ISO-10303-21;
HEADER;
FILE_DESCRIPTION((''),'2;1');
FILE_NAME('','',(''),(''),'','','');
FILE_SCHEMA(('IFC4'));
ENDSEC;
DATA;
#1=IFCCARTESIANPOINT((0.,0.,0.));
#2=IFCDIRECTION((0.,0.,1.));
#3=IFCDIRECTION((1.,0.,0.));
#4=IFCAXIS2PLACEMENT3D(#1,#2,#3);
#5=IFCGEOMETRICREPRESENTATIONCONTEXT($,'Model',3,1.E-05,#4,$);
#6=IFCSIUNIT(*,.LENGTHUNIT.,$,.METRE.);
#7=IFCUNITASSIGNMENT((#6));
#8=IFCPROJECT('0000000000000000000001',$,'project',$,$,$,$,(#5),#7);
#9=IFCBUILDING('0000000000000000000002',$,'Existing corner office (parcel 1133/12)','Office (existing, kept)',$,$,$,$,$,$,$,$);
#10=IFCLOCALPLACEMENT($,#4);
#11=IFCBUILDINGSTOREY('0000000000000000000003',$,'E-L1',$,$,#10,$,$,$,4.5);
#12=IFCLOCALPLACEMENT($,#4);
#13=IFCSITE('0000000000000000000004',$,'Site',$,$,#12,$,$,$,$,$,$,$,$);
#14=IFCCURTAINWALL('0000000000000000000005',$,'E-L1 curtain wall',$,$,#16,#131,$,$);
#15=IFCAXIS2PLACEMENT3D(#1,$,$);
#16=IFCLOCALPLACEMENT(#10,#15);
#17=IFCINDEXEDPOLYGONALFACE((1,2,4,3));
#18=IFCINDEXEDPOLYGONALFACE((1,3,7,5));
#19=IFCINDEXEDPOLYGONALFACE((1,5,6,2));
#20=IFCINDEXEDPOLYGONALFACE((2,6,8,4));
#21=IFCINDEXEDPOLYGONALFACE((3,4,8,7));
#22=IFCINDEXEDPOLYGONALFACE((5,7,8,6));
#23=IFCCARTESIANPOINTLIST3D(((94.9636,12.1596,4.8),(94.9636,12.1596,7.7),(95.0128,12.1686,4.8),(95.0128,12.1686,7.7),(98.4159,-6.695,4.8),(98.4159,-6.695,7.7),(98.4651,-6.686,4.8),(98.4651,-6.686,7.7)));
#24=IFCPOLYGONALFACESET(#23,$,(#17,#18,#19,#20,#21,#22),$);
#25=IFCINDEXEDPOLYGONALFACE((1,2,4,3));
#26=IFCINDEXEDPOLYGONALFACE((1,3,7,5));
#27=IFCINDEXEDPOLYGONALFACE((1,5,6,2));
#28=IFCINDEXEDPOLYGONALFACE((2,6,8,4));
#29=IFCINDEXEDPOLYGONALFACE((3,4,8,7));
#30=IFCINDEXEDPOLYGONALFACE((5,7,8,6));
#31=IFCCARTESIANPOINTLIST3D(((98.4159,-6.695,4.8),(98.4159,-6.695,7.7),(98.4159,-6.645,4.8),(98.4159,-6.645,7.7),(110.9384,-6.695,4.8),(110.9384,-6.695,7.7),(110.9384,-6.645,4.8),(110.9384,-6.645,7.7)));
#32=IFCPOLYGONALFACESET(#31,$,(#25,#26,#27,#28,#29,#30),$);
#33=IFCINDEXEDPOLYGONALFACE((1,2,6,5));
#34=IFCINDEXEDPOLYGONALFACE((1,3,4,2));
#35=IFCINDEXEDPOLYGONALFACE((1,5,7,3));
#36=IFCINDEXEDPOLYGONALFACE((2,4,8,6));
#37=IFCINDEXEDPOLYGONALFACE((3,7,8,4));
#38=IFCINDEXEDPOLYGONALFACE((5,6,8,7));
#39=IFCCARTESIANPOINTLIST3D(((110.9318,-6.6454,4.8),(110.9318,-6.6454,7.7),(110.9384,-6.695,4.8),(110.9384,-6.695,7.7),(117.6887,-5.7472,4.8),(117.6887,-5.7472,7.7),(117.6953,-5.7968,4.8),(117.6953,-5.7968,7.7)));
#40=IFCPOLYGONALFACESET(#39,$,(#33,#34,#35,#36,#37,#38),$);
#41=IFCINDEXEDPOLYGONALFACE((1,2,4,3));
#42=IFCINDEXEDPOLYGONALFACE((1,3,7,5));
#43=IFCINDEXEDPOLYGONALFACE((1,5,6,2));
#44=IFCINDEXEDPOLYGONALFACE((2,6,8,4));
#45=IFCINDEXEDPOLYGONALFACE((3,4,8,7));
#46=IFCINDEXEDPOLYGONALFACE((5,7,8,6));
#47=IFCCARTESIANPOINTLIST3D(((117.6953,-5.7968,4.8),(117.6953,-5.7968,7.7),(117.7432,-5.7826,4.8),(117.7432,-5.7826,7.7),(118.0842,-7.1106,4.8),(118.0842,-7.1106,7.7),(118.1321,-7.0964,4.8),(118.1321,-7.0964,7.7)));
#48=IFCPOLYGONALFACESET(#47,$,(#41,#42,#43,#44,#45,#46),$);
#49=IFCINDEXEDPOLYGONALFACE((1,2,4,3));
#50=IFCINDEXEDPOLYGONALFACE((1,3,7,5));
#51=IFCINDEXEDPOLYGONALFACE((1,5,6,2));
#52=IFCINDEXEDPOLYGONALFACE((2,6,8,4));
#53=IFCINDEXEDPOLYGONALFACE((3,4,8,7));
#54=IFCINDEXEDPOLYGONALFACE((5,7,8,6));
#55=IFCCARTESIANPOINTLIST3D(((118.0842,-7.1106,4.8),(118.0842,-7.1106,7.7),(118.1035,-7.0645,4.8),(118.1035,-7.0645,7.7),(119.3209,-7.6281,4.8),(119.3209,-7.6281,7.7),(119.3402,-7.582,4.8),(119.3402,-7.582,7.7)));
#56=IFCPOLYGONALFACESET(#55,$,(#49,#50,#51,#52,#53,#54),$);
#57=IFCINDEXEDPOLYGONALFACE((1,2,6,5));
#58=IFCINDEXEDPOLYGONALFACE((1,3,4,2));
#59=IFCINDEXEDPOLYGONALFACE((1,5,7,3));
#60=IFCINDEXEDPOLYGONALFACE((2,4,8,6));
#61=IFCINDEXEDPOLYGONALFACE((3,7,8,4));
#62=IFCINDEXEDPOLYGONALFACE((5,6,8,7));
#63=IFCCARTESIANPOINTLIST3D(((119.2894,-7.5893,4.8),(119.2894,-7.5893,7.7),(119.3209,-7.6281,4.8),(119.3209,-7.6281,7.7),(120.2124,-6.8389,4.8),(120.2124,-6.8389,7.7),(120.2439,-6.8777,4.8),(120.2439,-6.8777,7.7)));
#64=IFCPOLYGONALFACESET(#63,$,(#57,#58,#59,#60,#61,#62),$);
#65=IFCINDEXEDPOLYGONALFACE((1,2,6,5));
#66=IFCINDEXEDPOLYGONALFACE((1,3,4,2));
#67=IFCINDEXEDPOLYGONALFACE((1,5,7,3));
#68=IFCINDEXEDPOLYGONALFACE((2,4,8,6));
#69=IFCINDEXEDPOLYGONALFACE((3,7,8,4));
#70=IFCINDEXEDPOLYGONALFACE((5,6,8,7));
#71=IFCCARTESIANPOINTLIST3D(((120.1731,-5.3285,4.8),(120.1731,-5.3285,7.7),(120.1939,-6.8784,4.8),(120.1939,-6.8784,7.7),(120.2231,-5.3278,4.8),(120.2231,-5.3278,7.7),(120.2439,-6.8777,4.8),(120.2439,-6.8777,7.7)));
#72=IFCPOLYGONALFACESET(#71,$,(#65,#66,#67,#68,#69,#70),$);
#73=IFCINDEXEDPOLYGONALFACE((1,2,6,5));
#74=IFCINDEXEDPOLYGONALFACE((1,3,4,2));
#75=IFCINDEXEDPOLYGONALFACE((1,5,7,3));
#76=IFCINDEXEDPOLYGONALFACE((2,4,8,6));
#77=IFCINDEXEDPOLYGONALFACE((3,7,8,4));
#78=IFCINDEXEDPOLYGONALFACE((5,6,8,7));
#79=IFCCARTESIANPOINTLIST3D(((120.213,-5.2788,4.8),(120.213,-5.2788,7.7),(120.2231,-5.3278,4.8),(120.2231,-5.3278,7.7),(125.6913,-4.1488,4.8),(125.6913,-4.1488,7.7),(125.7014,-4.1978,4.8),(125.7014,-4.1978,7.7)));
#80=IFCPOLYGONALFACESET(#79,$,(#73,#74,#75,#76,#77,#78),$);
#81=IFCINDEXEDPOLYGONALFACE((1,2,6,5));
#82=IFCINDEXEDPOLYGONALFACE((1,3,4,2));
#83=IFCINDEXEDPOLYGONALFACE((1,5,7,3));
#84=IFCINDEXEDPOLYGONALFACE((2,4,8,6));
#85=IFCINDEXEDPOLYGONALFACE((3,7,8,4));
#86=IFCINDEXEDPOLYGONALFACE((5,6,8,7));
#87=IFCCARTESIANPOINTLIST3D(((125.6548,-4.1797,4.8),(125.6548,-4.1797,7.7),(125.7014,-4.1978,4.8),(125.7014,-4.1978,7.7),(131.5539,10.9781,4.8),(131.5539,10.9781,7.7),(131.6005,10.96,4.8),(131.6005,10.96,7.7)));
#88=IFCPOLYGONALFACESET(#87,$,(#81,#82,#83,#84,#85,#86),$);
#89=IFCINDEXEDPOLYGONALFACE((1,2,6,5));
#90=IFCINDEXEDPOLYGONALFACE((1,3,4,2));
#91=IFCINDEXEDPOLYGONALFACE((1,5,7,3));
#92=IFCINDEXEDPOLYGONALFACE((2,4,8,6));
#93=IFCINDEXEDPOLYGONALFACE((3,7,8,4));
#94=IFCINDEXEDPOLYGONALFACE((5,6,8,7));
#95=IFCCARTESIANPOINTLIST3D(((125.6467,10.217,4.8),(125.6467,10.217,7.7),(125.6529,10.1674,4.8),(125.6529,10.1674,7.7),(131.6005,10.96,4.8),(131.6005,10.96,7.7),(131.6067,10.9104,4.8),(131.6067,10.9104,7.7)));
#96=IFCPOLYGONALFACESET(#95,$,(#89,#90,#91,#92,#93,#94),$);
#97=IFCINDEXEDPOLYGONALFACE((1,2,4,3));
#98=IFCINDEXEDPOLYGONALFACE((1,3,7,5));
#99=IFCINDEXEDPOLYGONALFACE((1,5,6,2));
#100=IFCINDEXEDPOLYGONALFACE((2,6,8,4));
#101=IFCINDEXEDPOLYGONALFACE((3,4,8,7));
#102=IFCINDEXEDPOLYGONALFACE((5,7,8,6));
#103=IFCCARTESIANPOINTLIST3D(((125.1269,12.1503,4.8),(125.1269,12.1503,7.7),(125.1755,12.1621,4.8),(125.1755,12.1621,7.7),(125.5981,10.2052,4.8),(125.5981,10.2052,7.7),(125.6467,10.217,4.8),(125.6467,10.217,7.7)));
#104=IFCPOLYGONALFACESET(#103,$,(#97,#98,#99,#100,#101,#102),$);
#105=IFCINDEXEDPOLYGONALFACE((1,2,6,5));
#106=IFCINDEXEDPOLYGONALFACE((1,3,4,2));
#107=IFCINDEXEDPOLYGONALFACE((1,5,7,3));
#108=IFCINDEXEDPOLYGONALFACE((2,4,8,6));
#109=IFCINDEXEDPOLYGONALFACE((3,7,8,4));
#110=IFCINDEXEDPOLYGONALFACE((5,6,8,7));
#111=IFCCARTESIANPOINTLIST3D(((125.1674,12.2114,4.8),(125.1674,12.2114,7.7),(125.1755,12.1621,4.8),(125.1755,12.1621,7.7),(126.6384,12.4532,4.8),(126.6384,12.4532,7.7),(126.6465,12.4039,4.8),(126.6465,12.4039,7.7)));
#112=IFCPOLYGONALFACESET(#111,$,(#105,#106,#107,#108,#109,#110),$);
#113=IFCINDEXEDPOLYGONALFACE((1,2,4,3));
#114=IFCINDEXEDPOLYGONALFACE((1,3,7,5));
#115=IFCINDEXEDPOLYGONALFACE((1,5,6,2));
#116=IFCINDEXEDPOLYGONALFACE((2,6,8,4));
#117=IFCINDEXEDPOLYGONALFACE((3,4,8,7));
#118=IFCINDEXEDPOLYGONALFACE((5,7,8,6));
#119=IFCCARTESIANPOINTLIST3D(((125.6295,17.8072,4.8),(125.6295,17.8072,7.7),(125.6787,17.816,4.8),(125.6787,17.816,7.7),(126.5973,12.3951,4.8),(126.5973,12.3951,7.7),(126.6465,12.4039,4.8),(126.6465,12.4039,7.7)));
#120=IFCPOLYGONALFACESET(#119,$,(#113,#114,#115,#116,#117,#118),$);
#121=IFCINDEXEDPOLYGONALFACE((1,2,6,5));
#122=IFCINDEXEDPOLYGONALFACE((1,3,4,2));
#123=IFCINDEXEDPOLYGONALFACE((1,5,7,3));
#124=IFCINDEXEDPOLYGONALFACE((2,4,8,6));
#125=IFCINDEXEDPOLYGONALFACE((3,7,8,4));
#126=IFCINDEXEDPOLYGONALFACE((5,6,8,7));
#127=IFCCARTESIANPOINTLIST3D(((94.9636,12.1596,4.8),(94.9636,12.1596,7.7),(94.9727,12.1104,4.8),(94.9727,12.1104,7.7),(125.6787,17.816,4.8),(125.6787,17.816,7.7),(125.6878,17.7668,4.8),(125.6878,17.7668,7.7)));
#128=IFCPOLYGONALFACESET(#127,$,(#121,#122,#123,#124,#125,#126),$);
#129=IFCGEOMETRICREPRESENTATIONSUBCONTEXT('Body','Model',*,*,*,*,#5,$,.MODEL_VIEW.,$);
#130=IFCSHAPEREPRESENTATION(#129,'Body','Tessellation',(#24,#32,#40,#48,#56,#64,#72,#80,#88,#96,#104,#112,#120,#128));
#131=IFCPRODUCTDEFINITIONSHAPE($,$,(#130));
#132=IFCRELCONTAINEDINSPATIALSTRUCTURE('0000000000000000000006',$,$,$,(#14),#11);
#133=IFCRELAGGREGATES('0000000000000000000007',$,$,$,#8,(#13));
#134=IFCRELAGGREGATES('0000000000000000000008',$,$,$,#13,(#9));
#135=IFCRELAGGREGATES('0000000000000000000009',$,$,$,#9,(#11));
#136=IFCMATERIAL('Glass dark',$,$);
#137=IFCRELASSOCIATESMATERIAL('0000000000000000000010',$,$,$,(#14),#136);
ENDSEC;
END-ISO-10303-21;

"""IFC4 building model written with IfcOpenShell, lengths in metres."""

from ifc_helpers import new_model, si_unit, frame, origin_with_axes, place, context, subcontext, project, spatial, polyline, outline, extrude, material, element, save


model = new_model("IFC4")

# Units and contexts
model_context = context("Model", 3, precision=1e-05, world=origin_with_axes())
body_context = subcontext(model_context, "Body", "Model", "MODEL_VIEW")
ifc_project = project(units=[si_unit("LENGTHUNIT", "METRE")], contexts=[model_context])

# Site, building, storey
site_placement = place(None, origin_with_axes())
site = spatial("IfcSite", under=ifc_project, at=site_placement, Name="Site")
building = spatial("IfcBuilding", under=site, Name="Existing corner office (parcel 1133/12)", Description="Office (existing, kept)")
storey_placement = place(None, origin_with_axes())
storey = spatial("IfcBuildingStorey", under=building, at=storey_placement, Name="E-L1", Elevation=4.5)

# Curtain wall
ifc_material_1 = material(Name="Glass dark")
curtain_wall_placement = place(storey_placement, origin_with_axes())
element("IfcCurtainWall", 1, at=curtain_wall_placement, inside=storey, material=ifc_material_1, Name="E-L1 curtain wall", context=body_context, shape_type="SweptSolid", body=[
    extrude(outline(polyline([(94.9636, 12.1596), (98.4159, -6.695), (98.4651, -6.686), (95.0128, 12.1686), (94.9636, 12.1596)])), frame((0.0, 0.0, 4.8), z_axis=(0.0, 0.0, 1.0), x_axis=(1.0, 0.0, 0.0)), (0.0, 0.0, 1.0), 2.9),
    extrude(outline(polyline([(98.4159, -6.695), (110.9384, -6.695), (110.9384, -6.645), (98.4159, -6.645), (98.4159, -6.695)])), frame((0.0, 0.0, 4.8), z_axis=(0.0, 0.0, 1.0), x_axis=(1.0, 0.0, 0.0)), (0.0, 0.0, 1.0), 2.9),
    extrude(outline(polyline([(110.9384, -6.695), (117.6953, -5.7968), (117.6887, -5.7472), (110.9318, -6.6454), (110.9384, -6.695)])), frame((0.0, 0.0, 4.8), z_axis=(0.0, 0.0, 1.0), x_axis=(1.0, 0.0, 0.0)), (0.0, 0.0, 1.0), 2.9),
    extrude(outline(polyline([(117.6953, -5.7968), (118.0842, -7.1106), (118.1321, -7.0964), (117.7432, -5.7826), (117.6953, -5.7968)])), frame((0.0, 0.0, 4.8), z_axis=(0.0, 0.0, 1.0), x_axis=(1.0, 0.0, 0.0)), (0.0, 0.0, 1.0), 2.9),
    extrude(outline(polyline([(118.0842, -7.1106), (119.3209, -7.6281), (119.3402, -7.582), (118.1035, -7.0645), (118.0842, -7.1106)])), frame((0.0, 0.0, 4.8), z_axis=(0.0, 0.0, 1.0), x_axis=(1.0, 0.0, 0.0)), (0.0, 0.0, 1.0), 2.9),
    extrude(outline(polyline([(119.3209, -7.6281), (120.2439, -6.8777), (120.2124, -6.8389), (119.2894, -7.5893), (119.3209, -7.6281)])), frame((0.0, 0.0, 4.8), z_axis=(0.0, 0.0, 1.0), x_axis=(1.0, 0.0, 0.0)), (0.0, 0.0, 1.0), 2.9),
    extrude(outline(polyline([(120.2439, -6.8777), (120.2231, -5.3278), (120.1731, -5.3285), (120.1939, -6.8784), (120.2439, -6.8777)])), frame((0.0, 0.0, 4.8), z_axis=(0.0, 0.0, 1.0), x_axis=(1.0, 0.0, 0.0)), (0.0, 0.0, 1.0), 2.9),
    extrude(outline(polyline([(120.2231, -5.3278), (125.7014, -4.1978), (125.6913, -4.1488), (120.213, -5.2788), (120.2231, -5.3278)])), frame((0.0, 0.0, 4.8), z_axis=(0.0, 0.0, 1.0), x_axis=(1.0, 0.0, 0.0)), (0.0, 0.0, 1.0), 2.9),
    extrude(outline(polyline([(125.7014, -4.1978), (131.6005, 10.96), (131.5539, 10.9781), (125.6548, -4.1797), (125.7014, -4.1978)])), frame((0.0, 0.0, 4.8), z_axis=(0.0, 0.0, 1.0), x_axis=(1.0, 0.0, 0.0)), (0.0, 0.0, 1.0), 2.9),
    extrude(outline(polyline([(131.6005, 10.96), (125.6467, 10.217), (125.6529, 10.1674), (131.6067, 10.9104), (131.6005, 10.96)])), frame((0.0, 0.0, 4.8), z_axis=(0.0, 0.0, 1.0), x_axis=(1.0, 0.0, 0.0)), (0.0, 0.0, 1.0), 2.9),
    extrude(outline(polyline([(125.6467, 10.217), (125.1755, 12.1621), (125.1269, 12.1503), (125.5981, 10.2052), (125.6467, 10.217)])), frame((0.0, 0.0, 4.8), z_axis=(0.0, 0.0, 1.0), x_axis=(1.0, 0.0, 0.0)), (0.0, 0.0, 1.0), 2.9),
    extrude(outline(polyline([(125.1755, 12.1621), (126.6465, 12.4039), (126.6384, 12.4532), (125.1674, 12.2114), (125.1755, 12.1621)])), frame((0.0, 0.0, 4.8), z_axis=(0.0, 0.0, 1.0), x_axis=(1.0, 0.0, 0.0)), (0.0, 0.0, 1.0), 2.9),
    extrude(outline(polyline([(126.6465, 12.4039), (125.6787, 17.816), (125.6295, 17.8072), (126.5973, 12.3951), (126.6465, 12.4039)])), frame((0.0, 0.0, 4.8), z_axis=(0.0, 0.0, 1.0), x_axis=(1.0, 0.0, 0.0)), (0.0, 0.0, 1.0), 2.9),
    extrude(outline(polyline([(125.6787, 17.816), (94.9636, 12.1596), (94.9727, 12.1104), (125.6878, 17.7668), (125.6787, 17.816)])), frame((0.0, 0.0, 4.8), z_axis=(0.0, 0.0, 1.0), x_axis=(1.0, 0.0, 0.0)), (0.0, 0.0, 1.0), 2.9),
])

save(model, "model.ifc")
